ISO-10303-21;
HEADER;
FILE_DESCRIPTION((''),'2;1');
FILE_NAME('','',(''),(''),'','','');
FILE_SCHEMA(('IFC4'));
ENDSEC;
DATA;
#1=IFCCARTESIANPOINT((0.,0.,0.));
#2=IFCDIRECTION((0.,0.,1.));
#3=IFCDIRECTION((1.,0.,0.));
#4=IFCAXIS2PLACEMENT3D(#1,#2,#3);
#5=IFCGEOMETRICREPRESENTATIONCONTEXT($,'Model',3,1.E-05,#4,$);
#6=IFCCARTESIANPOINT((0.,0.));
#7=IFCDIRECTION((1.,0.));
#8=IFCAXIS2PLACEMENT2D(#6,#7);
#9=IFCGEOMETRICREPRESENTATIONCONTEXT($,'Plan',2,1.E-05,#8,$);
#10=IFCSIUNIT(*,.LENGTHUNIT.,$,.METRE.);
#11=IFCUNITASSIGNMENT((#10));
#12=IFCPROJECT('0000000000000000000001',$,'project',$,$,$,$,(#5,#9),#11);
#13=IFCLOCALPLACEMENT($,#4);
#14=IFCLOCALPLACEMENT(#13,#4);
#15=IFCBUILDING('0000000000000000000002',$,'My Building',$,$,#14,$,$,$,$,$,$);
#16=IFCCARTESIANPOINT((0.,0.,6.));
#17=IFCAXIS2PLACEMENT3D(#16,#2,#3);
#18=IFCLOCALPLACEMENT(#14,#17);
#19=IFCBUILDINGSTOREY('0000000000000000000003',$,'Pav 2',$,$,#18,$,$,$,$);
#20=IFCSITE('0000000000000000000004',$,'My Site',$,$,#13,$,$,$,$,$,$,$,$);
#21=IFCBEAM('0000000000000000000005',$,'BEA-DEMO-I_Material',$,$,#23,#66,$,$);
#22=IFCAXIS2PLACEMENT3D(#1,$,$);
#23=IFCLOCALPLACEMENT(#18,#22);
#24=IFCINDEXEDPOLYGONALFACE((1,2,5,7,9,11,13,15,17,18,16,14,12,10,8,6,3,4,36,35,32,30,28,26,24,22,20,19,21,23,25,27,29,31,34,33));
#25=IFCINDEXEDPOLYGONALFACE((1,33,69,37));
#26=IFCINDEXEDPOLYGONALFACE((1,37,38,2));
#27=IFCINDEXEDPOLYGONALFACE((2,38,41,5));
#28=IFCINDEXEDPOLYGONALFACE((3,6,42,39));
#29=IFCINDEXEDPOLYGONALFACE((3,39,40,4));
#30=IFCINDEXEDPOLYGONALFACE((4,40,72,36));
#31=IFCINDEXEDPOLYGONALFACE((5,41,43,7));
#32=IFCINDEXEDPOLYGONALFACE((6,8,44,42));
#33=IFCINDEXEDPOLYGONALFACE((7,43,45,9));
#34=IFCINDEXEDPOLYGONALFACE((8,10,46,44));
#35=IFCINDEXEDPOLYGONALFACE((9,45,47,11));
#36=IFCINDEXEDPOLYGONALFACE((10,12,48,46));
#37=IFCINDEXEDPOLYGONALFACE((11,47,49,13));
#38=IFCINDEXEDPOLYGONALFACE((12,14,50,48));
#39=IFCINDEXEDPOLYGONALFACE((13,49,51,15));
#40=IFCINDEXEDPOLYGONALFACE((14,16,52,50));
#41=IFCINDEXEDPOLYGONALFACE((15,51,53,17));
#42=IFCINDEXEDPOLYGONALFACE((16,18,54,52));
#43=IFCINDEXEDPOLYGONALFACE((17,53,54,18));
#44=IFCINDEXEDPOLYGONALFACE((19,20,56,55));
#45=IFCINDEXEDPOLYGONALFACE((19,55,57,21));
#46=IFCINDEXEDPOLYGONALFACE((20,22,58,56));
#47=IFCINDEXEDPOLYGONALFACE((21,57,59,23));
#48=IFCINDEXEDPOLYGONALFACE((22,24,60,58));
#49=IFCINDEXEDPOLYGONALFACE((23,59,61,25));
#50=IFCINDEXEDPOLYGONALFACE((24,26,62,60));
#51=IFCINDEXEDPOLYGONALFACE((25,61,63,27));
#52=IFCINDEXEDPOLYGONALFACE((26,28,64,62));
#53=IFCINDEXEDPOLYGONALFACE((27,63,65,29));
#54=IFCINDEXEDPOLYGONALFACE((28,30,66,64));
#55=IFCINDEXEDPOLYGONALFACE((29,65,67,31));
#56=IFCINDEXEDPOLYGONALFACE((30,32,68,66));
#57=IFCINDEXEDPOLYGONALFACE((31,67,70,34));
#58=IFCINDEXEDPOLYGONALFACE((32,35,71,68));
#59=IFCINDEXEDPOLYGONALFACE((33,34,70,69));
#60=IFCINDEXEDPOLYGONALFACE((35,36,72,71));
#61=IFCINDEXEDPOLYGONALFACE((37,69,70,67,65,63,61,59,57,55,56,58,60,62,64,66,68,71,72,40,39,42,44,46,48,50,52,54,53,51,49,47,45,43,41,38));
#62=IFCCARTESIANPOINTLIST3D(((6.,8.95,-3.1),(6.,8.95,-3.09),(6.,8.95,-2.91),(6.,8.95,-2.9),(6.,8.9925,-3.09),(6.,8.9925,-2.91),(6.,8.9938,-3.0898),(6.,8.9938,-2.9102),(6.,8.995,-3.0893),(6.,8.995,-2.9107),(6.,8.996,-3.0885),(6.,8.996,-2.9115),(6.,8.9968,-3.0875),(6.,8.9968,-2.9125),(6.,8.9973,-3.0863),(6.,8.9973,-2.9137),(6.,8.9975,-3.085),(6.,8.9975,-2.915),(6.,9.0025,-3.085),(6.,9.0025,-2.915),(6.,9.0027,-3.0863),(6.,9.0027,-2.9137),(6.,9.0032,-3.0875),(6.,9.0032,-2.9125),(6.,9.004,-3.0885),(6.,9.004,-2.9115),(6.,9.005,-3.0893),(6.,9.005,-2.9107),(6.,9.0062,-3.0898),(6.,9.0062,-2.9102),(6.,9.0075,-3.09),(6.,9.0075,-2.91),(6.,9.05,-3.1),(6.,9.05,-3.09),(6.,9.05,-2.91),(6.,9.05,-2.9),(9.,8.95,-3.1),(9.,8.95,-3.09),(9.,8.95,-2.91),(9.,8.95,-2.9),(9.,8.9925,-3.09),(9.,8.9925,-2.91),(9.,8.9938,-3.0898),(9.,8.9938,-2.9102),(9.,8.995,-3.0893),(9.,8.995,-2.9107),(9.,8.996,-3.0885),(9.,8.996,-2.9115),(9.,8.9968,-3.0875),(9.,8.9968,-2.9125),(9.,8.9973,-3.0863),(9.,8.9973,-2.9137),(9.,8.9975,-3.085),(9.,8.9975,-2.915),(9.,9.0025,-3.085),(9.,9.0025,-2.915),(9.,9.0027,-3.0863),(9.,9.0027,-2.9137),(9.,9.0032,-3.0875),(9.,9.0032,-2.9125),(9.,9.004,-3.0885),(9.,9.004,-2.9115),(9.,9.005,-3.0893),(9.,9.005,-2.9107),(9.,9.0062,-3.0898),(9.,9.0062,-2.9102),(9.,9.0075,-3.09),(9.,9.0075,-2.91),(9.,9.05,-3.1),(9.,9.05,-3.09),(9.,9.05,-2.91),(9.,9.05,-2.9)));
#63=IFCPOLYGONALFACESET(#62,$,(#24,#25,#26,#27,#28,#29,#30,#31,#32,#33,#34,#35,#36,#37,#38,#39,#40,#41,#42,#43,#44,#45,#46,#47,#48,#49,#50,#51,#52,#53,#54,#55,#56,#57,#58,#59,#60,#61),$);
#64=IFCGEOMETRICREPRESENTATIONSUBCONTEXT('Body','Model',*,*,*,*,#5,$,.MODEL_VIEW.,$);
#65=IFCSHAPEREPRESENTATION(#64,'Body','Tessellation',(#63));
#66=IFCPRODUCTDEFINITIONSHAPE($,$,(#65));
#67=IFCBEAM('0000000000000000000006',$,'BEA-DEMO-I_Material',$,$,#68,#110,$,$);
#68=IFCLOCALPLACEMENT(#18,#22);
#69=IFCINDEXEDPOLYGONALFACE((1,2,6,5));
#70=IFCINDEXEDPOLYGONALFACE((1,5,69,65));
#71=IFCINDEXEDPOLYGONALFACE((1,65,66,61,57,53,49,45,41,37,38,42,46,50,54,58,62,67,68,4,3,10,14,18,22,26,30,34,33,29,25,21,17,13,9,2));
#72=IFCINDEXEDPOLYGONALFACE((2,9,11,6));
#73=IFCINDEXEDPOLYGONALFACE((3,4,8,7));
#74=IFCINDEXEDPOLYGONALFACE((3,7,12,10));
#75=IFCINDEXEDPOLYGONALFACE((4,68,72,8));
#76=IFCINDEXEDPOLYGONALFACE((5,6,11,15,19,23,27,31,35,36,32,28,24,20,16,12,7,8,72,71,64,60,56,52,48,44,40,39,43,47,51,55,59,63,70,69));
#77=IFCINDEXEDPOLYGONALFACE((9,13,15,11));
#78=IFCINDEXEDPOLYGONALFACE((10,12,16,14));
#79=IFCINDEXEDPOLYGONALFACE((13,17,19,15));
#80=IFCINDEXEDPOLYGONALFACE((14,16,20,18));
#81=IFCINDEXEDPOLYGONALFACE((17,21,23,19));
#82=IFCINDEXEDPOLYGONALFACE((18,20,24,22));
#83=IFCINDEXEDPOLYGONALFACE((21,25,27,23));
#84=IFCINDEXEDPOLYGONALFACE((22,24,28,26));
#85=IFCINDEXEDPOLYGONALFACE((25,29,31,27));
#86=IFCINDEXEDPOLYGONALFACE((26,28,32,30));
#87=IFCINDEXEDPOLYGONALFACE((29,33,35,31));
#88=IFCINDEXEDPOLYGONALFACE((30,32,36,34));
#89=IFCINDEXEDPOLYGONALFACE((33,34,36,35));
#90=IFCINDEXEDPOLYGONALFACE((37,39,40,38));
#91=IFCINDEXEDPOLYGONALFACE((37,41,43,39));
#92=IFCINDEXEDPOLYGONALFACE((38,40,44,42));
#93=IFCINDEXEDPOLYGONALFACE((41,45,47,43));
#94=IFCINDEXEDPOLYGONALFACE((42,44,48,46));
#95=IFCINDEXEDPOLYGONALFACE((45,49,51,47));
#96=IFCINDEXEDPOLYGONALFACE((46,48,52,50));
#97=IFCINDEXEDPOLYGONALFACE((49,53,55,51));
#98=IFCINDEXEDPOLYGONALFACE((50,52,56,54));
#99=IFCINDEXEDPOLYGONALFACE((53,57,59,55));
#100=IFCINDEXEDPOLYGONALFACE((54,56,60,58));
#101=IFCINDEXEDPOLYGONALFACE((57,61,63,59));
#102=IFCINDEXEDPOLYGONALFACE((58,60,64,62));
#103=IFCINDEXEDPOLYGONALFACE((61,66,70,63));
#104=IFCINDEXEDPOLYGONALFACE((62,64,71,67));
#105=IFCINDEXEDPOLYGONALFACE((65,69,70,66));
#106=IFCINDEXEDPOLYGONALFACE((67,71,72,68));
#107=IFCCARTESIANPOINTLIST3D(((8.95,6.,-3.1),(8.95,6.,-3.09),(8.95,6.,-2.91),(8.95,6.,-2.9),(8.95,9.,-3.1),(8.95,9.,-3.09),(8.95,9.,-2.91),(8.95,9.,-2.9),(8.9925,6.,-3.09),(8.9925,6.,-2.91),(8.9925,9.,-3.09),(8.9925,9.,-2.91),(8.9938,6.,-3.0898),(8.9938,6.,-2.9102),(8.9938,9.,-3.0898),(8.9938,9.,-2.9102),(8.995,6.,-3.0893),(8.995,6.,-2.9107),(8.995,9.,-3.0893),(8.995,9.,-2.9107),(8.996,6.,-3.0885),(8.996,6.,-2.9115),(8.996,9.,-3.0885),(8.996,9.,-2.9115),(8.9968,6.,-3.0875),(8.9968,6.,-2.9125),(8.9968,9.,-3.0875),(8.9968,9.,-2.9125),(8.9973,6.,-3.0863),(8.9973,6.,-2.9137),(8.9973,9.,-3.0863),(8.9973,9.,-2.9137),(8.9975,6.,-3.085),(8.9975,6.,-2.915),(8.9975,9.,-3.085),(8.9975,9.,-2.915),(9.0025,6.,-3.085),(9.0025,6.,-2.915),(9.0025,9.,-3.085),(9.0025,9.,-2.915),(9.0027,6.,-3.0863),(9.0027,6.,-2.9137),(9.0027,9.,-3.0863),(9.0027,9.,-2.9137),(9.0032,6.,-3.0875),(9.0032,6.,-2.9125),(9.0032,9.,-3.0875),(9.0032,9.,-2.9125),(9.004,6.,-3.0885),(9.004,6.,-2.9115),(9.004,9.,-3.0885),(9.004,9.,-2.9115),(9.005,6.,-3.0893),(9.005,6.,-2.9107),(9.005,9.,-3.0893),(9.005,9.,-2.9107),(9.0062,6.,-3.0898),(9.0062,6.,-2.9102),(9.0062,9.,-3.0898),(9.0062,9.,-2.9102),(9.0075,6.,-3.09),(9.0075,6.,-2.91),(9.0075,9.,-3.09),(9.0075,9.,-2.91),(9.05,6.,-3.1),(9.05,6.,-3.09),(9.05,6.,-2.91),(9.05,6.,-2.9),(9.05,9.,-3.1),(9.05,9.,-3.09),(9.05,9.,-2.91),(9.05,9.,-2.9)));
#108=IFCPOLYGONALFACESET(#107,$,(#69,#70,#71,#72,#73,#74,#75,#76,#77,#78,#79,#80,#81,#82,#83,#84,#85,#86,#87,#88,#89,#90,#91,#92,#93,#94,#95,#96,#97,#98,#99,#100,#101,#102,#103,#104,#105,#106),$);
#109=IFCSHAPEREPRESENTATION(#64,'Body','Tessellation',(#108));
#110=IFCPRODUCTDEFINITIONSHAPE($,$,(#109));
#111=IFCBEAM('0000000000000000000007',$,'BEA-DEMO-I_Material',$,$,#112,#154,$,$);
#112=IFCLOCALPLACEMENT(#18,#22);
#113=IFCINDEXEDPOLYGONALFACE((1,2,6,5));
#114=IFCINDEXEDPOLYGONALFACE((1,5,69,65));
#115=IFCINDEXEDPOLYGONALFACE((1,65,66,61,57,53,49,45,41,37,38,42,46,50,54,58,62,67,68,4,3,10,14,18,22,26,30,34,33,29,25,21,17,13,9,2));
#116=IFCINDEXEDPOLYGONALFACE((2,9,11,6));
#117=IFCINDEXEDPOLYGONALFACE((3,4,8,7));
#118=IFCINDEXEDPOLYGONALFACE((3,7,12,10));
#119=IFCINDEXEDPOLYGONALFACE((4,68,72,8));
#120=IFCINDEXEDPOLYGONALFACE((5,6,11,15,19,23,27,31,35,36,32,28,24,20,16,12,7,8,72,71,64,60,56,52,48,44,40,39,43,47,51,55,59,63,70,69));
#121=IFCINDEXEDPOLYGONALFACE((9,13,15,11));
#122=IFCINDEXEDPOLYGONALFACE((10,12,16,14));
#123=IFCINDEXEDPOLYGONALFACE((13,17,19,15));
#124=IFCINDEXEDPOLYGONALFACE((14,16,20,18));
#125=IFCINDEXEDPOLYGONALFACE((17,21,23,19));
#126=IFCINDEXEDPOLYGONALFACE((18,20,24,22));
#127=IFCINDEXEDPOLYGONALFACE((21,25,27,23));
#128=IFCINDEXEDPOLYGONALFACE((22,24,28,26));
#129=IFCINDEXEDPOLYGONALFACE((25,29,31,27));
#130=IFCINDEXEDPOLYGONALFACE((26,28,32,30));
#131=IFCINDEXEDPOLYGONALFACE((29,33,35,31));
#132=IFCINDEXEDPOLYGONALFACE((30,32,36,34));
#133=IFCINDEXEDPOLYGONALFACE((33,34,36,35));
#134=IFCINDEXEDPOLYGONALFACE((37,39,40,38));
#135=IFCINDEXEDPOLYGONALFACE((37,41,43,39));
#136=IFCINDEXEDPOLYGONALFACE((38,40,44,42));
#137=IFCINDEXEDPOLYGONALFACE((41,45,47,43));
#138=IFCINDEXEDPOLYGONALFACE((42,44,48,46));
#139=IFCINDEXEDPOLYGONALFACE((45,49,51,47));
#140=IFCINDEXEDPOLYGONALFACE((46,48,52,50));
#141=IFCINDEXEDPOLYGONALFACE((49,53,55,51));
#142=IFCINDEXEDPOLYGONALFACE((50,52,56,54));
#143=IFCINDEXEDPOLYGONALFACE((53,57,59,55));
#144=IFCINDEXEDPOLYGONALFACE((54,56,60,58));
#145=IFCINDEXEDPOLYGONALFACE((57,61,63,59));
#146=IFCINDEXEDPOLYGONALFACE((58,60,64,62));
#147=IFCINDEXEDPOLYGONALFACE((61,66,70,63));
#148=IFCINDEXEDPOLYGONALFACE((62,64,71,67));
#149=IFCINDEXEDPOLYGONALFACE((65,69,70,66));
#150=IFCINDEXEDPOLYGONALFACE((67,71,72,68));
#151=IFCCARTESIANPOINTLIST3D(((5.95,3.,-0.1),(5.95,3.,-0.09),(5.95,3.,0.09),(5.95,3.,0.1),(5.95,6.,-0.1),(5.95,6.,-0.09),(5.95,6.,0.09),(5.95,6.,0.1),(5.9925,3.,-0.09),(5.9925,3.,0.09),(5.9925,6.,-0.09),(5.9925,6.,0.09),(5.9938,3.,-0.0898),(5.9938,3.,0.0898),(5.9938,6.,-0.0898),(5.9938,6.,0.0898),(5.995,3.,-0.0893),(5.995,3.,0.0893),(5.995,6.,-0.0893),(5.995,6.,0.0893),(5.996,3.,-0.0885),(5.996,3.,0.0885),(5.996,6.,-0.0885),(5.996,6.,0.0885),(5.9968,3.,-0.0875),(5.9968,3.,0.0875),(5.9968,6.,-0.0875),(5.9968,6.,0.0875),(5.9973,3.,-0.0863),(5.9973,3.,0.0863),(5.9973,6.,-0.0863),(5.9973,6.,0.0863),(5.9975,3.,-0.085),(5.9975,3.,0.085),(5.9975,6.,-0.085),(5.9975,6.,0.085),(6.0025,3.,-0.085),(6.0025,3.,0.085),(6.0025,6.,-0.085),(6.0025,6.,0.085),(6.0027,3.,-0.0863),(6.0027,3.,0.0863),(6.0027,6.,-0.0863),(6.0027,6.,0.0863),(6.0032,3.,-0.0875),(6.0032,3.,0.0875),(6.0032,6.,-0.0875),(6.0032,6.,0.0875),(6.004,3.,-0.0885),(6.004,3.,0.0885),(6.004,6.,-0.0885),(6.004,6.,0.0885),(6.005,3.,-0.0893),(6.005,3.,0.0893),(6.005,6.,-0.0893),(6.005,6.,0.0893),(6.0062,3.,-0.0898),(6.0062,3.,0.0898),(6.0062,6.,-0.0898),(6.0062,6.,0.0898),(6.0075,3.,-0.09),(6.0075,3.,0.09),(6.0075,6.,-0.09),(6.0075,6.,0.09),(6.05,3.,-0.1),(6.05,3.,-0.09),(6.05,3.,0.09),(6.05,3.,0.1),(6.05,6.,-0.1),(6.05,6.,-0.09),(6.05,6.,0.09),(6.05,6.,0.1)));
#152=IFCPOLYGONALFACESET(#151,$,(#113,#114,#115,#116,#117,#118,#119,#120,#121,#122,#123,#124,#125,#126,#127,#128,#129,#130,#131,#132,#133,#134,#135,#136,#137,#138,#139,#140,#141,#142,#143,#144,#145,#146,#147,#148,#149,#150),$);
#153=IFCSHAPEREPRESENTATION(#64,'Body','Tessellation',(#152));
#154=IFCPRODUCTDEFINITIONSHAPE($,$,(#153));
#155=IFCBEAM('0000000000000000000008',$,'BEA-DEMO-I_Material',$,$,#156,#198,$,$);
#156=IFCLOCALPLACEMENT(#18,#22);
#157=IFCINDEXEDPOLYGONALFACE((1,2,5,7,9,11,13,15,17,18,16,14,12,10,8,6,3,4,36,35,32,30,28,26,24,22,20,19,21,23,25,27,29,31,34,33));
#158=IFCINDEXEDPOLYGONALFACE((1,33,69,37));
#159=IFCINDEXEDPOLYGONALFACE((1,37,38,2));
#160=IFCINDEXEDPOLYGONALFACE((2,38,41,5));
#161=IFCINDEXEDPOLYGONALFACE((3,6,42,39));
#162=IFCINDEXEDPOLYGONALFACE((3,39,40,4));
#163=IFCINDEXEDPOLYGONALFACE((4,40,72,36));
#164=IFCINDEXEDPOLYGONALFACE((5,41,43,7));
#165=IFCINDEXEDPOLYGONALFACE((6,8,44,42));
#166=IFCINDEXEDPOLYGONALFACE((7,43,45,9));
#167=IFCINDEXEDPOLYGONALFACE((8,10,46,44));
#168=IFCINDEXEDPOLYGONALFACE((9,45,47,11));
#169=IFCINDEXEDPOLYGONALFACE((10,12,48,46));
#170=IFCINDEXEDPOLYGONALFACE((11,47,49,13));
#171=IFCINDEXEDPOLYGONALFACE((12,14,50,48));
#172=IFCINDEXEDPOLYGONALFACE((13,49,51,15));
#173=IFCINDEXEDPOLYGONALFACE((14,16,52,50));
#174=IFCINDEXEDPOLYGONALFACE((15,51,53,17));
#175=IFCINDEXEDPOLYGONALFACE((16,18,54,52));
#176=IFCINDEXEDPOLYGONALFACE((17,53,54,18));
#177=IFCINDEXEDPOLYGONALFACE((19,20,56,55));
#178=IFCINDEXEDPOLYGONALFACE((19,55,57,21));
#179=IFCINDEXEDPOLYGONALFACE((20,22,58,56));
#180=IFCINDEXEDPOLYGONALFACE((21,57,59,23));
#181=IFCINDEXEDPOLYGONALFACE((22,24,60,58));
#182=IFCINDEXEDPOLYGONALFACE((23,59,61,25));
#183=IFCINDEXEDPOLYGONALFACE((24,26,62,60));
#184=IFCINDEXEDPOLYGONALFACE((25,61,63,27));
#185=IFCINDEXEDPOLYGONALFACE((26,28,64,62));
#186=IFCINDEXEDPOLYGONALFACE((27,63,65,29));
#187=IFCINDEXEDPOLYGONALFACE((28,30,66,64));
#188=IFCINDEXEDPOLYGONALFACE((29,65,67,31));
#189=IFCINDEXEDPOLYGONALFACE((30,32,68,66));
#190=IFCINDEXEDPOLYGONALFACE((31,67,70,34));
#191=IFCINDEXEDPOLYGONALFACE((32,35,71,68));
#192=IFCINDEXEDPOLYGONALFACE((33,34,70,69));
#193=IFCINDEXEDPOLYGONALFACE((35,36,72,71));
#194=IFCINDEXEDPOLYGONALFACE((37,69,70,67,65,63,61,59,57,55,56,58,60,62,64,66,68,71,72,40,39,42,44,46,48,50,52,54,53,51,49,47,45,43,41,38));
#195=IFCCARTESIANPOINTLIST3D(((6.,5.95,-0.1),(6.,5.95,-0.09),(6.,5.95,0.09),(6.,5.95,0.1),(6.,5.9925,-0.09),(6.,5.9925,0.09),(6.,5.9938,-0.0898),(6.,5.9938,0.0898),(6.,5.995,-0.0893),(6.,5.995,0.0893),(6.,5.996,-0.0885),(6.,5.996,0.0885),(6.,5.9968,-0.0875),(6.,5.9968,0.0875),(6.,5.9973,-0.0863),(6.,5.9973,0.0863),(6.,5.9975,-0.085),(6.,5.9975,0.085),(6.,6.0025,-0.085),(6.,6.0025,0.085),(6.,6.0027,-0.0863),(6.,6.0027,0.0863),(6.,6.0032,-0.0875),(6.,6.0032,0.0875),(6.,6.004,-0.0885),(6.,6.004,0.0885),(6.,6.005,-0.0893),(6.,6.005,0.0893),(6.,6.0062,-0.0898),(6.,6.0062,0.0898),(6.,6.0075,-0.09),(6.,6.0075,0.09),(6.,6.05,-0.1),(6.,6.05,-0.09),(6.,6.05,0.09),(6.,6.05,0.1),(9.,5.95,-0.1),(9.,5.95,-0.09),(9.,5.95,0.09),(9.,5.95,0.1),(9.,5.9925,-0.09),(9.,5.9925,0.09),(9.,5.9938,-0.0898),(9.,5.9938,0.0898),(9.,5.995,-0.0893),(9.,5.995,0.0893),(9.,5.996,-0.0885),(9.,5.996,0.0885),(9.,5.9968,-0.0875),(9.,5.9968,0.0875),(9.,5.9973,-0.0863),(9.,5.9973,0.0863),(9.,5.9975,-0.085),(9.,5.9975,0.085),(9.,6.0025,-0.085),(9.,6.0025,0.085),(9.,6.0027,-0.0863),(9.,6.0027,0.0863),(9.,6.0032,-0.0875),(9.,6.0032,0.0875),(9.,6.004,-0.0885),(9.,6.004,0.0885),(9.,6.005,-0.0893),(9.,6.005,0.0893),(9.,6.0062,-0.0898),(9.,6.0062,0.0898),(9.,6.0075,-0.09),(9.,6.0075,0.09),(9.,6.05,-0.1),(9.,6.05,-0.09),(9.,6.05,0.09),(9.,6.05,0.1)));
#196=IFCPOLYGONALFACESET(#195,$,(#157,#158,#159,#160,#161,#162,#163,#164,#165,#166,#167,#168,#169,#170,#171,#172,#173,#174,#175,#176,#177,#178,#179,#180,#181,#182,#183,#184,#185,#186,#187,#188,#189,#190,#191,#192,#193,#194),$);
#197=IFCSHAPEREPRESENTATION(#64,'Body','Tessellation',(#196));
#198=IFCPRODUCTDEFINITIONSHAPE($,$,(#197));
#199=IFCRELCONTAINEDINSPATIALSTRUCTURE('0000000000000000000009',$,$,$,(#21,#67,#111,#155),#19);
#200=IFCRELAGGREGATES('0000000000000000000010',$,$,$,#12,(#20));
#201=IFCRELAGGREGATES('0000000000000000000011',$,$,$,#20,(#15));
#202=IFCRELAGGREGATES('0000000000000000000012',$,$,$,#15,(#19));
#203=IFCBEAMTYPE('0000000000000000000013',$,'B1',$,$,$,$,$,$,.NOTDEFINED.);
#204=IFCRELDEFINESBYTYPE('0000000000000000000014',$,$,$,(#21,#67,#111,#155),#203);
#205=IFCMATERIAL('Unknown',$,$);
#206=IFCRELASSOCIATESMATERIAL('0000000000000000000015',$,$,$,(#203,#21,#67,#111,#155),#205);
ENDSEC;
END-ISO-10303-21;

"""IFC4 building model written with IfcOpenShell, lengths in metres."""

from ifc_helpers import new_model, si_unit, frame, origin, origin_with_axes, origin_2d_with_axis, place, context, subcontext, project, spatial, i_section, extrude, material, material_profile, profile_set, profile_usage, type_object, element, save


model = new_model("IFC4")

# Units and contexts
model_context = context("Model", 3, precision=1e-05, world=origin_with_axes())
plan_context = context("Plan", 2, precision=1e-05, world=origin_2d_with_axis())
body_context = subcontext(model_context, "Body", "Model", "MODEL_VIEW")
ifc_project = project(units=[si_unit("LENGTHUNIT", "METRE")], contexts=[model_context, plan_context])

# Site, building, storey
site_placement = place(None, origin_with_axes())
site = spatial("IfcSite", under=ifc_project, at=site_placement, Name="My Site")
building_placement = place(site_placement, origin_with_axes())
building = spatial("IfcBuilding", under=site, at=building_placement, Name="My Building")
storey_placement = place(building_placement, frame((0.0, 0.0, 6.0), z_axis=(0.0, 0.0, 1.0), x_axis=(1.0, 0.0, 0.0)))
storey = spatial("IfcBuildingStorey", under=building, at=storey_placement, Name="Pav 2")

# Beams
ifc_material = material(Name="Unknown")
ifc_material_profile = material_profile(ifc_material, i_section(OverallWidth=0.1, OverallDepth=0.2, WebThickness=0.005, FlangeThickness=0.01, FilletRadius=0.005))
ifc_profile_set = profile_set([ifc_material_profile])
beam_type = type_object("IfcBeamType", Name="B1", PredefinedType="NOTDEFINED", material=ifc_profile_set)
ifc_profile_usage_1 = profile_usage(ifc_profile_set, cardinal=5)
beam_1_placement = place(storey_placement, frame((6.0, 9.0, -3.0), z_axis=(1.0, 0.0, 0.0), x_axis=(0.0, 1.0, 0.0)))
element("IfcBeam", 1, at=beam_1_placement, inside=storey, type_object=beam_type, material=ifc_profile_usage_1, Name="BEA-DEMO-I_Material", context=body_context, shape_type="SweptSolid", body=[
    extrude(i_section(OverallWidth=0.1, OverallDepth=0.2, WebThickness=0.005, FlangeThickness=0.01, FilletRadius=0.005), origin(), (0.0, 0.0, 1.0), 3.0),
])
ifc_profile_usage_2 = profile_usage(ifc_profile_set, cardinal=5)
beam_2_placement = place(storey_placement, frame((9.0, 9.0, -3.0), z_axis=(0.0, -1.0, 0.0), x_axis=(1.0, 0.0, 0.0)))
element("IfcBeam", 2, at=beam_2_placement, inside=storey, type_object=beam_type, material=ifc_profile_usage_2, Name="BEA-DEMO-I_Material", context=body_context, shape_type="SweptSolid", body=[
    extrude(i_section(OverallWidth=0.1, OverallDepth=0.2, WebThickness=0.005, FlangeThickness=0.01, FilletRadius=0.005), origin(), (0.0, 0.0, 1.0), 3.0),
])
ifc_profile_usage_3 = profile_usage(ifc_profile_set, cardinal=5)
beam_3_placement = place(storey_placement, frame((6.0, 6.0, 0.0), z_axis=(0.0, -1.0, 0.0), x_axis=(1.0, 0.0, 0.0)))
element("IfcBeam", 3, at=beam_3_placement, inside=storey, type_object=beam_type, material=ifc_profile_usage_3, Name="BEA-DEMO-I_Material", context=body_context, shape_type="SweptSolid", body=[
    extrude(i_section(OverallWidth=0.1, OverallDepth=0.2, WebThickness=0.005, FlangeThickness=0.01, FilletRadius=0.005), origin(), (0.0, 0.0, 1.0), 3.0),
])
ifc_profile_usage_4 = profile_usage(ifc_profile_set, cardinal=5)
beam_4_placement = place(storey_placement, frame((6.0, 6.0, 0.0), z_axis=(1.0, 0.0, 0.0), x_axis=(0.0, 1.0, 0.0)))
element("IfcBeam", 4, at=beam_4_placement, inside=storey, type_object=beam_type, material=ifc_profile_usage_4, Name="BEA-DEMO-I_Material", context=body_context, shape_type="SweptSolid", body=[
    extrude(i_section(OverallWidth=0.1, OverallDepth=0.2, WebThickness=0.005, FlangeThickness=0.01, FilletRadius=0.005), origin(), (0.0, 0.0, 1.0), 3.0),
])

save(model, "model.ifc")
